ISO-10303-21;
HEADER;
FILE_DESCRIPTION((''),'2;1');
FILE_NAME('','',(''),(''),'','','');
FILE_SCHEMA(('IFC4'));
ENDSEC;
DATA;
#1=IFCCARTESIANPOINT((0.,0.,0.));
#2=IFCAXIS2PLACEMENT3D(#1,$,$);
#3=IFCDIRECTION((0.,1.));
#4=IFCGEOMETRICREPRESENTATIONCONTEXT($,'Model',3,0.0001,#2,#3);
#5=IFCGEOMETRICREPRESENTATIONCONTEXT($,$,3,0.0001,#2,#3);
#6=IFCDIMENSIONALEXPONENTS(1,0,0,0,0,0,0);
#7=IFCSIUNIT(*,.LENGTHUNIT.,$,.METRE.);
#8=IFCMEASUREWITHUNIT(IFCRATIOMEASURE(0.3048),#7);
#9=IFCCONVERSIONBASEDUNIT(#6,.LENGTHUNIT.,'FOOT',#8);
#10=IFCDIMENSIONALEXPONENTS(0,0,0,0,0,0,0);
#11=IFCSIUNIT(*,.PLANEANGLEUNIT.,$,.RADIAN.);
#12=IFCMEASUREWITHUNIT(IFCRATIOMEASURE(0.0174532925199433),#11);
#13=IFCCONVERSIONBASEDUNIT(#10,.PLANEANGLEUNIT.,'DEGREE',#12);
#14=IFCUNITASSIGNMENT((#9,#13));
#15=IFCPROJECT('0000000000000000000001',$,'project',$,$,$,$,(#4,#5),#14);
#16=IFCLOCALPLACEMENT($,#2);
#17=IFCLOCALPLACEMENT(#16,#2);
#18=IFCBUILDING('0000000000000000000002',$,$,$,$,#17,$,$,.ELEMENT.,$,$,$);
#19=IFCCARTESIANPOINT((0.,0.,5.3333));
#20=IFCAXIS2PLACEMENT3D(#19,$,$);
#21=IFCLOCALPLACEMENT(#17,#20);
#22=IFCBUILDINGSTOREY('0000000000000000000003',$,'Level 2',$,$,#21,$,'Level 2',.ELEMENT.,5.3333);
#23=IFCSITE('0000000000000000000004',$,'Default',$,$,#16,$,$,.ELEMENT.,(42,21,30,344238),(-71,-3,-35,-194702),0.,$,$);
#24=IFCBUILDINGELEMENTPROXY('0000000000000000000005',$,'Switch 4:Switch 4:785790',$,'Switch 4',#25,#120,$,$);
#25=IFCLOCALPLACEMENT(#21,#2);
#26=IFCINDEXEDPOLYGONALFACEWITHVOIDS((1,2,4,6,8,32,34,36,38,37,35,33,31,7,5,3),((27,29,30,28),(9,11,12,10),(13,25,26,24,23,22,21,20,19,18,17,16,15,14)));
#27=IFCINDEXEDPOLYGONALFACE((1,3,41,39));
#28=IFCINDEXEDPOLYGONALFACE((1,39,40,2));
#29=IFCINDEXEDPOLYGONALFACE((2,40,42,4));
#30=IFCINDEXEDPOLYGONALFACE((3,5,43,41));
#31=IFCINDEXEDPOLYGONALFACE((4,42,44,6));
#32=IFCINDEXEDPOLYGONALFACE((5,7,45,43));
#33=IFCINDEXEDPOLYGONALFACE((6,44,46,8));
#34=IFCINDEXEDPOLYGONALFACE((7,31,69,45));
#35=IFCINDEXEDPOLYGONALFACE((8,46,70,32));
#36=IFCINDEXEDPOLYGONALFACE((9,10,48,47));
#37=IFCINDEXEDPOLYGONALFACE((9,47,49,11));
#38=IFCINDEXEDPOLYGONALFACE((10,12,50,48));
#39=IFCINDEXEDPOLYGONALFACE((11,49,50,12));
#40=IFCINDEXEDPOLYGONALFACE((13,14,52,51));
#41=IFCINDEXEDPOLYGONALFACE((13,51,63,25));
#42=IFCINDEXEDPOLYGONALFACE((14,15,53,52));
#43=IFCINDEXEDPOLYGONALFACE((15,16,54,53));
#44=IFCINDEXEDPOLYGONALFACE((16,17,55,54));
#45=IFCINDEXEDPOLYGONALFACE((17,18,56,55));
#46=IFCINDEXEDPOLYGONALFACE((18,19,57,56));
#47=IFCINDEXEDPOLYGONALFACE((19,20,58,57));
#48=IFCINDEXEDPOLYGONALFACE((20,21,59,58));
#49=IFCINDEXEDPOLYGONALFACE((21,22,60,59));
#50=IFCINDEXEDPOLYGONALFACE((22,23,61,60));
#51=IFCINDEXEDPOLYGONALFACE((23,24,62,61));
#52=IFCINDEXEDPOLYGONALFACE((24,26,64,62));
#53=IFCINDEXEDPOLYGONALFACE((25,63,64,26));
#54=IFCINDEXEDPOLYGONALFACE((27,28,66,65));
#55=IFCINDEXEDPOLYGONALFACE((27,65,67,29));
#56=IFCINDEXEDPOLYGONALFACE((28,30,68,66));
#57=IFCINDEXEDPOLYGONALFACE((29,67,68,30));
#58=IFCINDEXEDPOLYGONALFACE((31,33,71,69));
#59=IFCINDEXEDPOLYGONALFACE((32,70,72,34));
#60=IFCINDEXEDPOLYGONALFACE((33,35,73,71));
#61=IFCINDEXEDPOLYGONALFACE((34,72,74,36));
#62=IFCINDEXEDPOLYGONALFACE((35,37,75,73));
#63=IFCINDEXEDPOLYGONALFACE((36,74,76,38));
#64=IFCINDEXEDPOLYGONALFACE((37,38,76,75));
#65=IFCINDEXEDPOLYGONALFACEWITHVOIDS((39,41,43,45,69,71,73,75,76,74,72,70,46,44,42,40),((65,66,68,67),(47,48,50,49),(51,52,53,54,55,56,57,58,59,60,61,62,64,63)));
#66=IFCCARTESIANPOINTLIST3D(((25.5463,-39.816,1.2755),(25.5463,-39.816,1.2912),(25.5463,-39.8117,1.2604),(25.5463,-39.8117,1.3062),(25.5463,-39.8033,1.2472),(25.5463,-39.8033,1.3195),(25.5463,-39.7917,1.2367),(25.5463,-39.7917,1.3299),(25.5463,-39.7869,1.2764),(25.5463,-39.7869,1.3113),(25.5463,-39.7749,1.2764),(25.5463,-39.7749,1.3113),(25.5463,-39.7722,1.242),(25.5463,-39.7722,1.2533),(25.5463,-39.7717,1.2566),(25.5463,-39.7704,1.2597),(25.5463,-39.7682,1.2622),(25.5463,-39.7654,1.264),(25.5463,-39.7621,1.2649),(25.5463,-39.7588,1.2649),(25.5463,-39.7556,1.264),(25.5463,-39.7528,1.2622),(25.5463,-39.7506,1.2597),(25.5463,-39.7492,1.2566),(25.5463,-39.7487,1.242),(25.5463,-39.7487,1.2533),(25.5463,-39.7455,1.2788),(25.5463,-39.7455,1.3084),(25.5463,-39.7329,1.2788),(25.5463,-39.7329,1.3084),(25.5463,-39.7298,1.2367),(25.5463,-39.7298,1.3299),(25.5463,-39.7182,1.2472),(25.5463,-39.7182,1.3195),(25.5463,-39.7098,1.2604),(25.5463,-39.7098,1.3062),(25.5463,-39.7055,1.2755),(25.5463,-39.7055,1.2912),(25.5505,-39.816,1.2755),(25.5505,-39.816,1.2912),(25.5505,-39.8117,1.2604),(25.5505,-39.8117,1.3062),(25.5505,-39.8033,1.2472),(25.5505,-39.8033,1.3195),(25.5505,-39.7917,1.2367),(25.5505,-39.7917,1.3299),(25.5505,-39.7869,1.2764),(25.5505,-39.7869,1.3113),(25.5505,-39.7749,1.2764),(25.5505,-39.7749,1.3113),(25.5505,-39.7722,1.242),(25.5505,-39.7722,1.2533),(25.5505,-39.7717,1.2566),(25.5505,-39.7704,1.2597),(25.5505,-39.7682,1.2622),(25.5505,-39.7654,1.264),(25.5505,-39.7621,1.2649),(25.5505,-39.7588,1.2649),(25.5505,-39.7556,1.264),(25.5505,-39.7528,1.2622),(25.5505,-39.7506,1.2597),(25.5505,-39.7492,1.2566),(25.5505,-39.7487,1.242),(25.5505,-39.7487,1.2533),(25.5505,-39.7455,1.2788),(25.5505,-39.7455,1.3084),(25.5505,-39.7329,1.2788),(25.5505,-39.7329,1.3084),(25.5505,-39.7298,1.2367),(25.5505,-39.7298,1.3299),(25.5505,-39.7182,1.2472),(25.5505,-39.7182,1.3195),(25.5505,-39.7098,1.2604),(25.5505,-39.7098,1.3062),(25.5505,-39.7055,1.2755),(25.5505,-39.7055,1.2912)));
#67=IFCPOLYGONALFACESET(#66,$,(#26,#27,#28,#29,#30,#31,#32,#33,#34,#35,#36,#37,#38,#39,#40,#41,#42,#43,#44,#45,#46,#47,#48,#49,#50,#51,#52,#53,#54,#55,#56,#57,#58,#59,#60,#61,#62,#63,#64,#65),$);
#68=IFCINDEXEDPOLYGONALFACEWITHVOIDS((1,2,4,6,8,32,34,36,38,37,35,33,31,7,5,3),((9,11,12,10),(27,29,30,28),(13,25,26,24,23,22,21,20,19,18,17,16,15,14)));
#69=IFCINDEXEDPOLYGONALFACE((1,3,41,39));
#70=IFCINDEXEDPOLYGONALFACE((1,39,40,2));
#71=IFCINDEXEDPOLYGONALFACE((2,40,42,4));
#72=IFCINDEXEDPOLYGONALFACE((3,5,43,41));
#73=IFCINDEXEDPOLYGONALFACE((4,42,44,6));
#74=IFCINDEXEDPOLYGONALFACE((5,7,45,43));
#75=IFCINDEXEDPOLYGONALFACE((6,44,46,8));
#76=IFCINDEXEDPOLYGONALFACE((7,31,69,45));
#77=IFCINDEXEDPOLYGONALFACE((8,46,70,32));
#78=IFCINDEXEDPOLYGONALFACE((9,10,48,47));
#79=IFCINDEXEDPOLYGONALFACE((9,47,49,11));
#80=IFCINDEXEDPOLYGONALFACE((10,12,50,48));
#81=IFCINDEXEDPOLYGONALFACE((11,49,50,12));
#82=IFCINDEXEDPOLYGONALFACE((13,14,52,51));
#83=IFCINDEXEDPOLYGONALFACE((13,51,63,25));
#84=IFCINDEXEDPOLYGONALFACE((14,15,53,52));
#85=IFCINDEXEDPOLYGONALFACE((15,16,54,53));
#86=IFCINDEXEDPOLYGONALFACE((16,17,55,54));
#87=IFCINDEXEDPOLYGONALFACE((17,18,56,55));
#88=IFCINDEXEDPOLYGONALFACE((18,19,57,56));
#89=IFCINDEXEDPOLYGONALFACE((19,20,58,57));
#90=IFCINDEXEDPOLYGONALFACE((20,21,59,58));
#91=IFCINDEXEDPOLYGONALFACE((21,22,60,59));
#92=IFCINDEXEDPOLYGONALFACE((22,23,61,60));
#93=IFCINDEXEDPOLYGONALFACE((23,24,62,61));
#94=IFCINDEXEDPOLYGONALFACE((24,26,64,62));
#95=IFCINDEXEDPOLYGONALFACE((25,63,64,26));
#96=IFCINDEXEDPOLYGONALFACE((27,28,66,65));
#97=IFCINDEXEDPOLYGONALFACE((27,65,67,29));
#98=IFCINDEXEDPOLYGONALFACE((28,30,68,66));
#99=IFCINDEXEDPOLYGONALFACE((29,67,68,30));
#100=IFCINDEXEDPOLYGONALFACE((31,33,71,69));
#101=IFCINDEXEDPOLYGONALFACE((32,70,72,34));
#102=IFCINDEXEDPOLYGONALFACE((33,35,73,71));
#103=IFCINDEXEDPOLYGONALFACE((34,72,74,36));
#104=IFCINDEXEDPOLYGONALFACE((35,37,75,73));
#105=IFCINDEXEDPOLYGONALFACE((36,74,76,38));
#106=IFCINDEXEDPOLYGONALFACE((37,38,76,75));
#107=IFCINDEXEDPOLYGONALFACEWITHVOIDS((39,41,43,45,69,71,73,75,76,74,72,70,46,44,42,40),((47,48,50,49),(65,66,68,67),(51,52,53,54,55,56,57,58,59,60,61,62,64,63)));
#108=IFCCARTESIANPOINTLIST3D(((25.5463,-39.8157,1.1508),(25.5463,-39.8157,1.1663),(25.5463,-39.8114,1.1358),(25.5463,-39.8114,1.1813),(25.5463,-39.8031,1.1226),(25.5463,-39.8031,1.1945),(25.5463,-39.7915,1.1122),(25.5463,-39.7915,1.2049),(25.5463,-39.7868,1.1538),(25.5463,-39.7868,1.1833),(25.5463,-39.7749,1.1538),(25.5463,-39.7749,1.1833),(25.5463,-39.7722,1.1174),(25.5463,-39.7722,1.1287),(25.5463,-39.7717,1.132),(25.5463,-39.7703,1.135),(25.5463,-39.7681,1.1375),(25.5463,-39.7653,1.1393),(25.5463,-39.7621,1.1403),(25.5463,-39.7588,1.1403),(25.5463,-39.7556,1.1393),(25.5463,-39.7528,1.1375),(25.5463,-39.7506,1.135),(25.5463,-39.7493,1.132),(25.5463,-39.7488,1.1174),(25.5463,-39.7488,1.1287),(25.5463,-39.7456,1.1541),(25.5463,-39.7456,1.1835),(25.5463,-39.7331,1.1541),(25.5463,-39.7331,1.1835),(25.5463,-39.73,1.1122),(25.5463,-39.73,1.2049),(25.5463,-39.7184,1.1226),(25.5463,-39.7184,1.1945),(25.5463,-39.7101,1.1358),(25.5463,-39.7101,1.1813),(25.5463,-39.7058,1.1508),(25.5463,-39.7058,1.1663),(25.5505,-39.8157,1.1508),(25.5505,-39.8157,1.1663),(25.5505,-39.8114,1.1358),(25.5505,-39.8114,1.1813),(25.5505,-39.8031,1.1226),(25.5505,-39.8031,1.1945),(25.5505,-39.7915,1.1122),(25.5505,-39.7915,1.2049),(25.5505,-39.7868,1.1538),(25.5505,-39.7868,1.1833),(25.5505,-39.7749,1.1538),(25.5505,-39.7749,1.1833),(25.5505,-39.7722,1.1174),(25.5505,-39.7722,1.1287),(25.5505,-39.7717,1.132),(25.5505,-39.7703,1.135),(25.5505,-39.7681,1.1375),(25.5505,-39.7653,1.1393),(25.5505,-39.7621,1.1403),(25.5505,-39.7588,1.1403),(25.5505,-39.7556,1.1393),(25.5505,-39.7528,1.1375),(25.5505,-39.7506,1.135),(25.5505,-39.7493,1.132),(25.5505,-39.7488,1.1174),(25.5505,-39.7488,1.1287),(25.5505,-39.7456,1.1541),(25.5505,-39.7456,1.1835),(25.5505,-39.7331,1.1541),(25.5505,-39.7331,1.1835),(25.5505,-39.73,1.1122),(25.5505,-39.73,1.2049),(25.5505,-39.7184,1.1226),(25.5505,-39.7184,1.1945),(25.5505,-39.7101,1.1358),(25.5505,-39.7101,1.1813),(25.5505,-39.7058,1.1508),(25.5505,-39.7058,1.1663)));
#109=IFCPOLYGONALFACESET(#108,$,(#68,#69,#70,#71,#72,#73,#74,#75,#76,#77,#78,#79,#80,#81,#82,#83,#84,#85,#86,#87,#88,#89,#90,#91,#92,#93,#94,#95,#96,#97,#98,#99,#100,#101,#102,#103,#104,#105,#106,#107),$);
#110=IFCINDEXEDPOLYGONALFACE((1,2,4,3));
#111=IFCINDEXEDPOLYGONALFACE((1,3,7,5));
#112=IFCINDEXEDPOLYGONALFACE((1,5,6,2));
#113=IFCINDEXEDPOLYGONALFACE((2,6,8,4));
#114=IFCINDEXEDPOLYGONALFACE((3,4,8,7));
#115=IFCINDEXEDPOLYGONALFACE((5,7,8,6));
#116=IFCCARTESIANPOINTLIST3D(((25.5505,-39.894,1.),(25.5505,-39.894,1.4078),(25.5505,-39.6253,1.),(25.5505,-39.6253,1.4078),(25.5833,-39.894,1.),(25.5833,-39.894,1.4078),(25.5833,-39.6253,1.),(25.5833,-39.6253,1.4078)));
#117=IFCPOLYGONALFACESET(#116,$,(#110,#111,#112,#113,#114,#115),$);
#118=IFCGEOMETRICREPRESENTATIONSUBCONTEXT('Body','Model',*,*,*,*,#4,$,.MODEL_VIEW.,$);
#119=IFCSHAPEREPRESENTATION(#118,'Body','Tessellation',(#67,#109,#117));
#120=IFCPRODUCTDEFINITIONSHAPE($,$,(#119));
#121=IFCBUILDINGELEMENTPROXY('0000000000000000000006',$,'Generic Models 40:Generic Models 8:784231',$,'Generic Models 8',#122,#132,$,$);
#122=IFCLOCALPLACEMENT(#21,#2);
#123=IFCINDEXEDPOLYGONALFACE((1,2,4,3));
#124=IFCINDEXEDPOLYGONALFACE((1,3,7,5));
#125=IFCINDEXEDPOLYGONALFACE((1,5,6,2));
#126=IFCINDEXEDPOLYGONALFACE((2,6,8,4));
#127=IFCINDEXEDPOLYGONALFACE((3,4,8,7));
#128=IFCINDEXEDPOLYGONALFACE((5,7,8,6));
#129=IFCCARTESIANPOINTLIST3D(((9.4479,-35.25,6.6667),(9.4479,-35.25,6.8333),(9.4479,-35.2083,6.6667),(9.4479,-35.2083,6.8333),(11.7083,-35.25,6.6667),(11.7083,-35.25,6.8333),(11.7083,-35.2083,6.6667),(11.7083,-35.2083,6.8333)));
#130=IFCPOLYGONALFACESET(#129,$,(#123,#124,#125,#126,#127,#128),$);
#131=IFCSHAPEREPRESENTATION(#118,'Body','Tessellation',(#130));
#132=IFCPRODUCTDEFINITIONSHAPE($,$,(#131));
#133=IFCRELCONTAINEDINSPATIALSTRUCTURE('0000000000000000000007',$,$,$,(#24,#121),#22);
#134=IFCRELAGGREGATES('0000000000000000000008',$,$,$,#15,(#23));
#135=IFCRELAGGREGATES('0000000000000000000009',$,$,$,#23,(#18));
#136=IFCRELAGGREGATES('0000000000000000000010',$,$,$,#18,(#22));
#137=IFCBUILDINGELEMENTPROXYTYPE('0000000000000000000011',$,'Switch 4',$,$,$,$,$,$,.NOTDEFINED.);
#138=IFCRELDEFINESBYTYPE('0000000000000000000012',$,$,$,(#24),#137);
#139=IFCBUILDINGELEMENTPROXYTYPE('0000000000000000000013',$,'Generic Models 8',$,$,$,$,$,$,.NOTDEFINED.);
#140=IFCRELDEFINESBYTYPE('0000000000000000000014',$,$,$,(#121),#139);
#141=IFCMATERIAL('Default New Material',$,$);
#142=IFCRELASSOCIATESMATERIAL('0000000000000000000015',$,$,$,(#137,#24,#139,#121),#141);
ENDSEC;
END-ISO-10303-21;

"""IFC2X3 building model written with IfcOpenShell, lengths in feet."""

from ifc_helpers import new_model, entity, si_unit, converted_unit, direction, frame, frame_2d, origin, origin_2d_with_axis, place, context, subcontext, project, spatial, polyline, circle_curve, parameter, trimmed, segment, composite_curve, rectangle, outline, extrude, source, transform, mapped, material, type_object, type_shapes, element, save


model = new_model("IFC2X3")

# Units and contexts
model_context = context("Model", 3, precision=0.0001, world=origin(), true_north=direction((0.0, 1.0)))
context_of_model = context(None, 3, precision=0.0001, world=origin(), true_north=direction((0.0, 1.0)))
body_context = subcontext(model_context, "Body", "Model", "MODEL_VIEW")
ifc_project = project(units=[converted_unit("LENGTHUNIT", "FOOT", entity("IfcRatioMeasure", 0.3048), si_unit("LENGTHUNIT", "METRE"), dimensions=[1, 0, 0, 0, 0, 0, 0]), converted_unit("PLANEANGLEUNIT", "DEGREE", entity("IfcRatioMeasure", 0.0174532925199433), si_unit("PLANEANGLEUNIT", "RADIAN"), dimensions=[0, 0, 0, 0, 0, 0, 0])], contexts=[model_context, context_of_model])

# Site, building, storey
site_placement = place(None, origin())
site = spatial("IfcSite", under=ifc_project, at=site_placement, Name="Default", CompositionType="ELEMENT", RefLatitude=(42, 21, 30, 344238), RefLongitude=(-71, -3, -35, -194702), RefElevation=0.0)
building_placement = place(site_placement, origin())
building = spatial("IfcBuilding", under=site, at=building_placement, CompositionType="ELEMENT")
storey_placement = place(building_placement, frame((0.0, 0.0, 5.3333)))
storey = spatial("IfcBuildingStorey", under=building, at=storey_placement, Name="Level 2", LongName="Level 2", CompositionType="ELEMENT", Elevation=5.3333)

# Shared definitions
ifc_material_1 = material(Name="Default New Material")

# Building element proxies
building_element_proxy_type_1 = type_object("IfcBuildingElementProxyType", Name="Switch 4", PredefinedType="NOTDEFINED", material=ifc_material_1)
shared_shape_1 = source(origin(), body_context, "Body", "SweptSolid", [
    extrude(outline(composite_curve([segment(polyline([(-0.0309, -0.0466), (0.0309, -0.0466)]), True, "CONTINUOUS"), segment(trimmed(circle_curve(frame_2d((-0.0003, 0.0), x_axis=(-1.0, 0.0)), 0.0561), [parameter(123.794741)], [parameter(236.205259)], True, "PARAMETER"), True, "CONTINUOUS"), segment(polyline([(0.0309, 0.0466), (-0.0309, 0.0466)]), True, "CONTINUOUS"), segment(trimmed(circle_curve(frame_2d((0.0003, 0.0), x_axis=(1.0, 0.0)), 0.0561), [parameter(123.794741)], [parameter(236.205259)], True, "PARAMETER"), True, "CONTINUOUS")], self_intersect=False), holes=[polyline([(0.0142, 0.0279), (0.0262, 0.0279), (0.0262, -0.0069), (0.0142, -0.0069), (0.0142, 0.0279)]), polyline([(-0.0153, 0.025), (-0.0153, -0.0045), (-0.0278, -0.0045), (-0.0278, 0.025), (-0.0153, 0.025)]), composite_curve([segment(polyline([(-0.012, -0.0413), (-0.012, -0.03)]), True, "CONTINUOUS"), segment(trimmed(circle_curve(frame_2d((-0.0003, -0.03), x_axis=(-1.0, 0.0)), 0.0117), [parameter(180.0)], [parameter(0.0)], True, "PARAMETER"), False, "CONTINUOUS"), segment(polyline([(0.0115, -0.03), (0.0115, -0.0413)]), True, "CONTINUOUS"), segment(polyline([(0.0115, -0.0413), (-0.012, -0.0413)]), True, "CONTINUOUS")], self_intersect=False)]), frame((-0.0011, 0.0328, 0.2833), z_axis=(0.0, 1.0, 0.0), x_axis=(-1.0, 0.0, 0.0)), (0.0, 0.0, 1.0), 0.0042),
    extrude(outline(composite_curve([segment(polyline([(-0.0308, -0.0464), (0.0308, -0.0464)]), True, "CONTINUOUS"), segment(trimmed(circle_curve(frame_2d((-0.0003, 0.0), x_axis=(-1.0, 0.0)), 0.0558), [parameter(123.794741)], [parameter(236.205259)], True, "PARAMETER"), True, "CONTINUOUS"), segment(polyline([(0.0308, 0.0464), (-0.0308, 0.0464)]), True, "CONTINUOUS"), segment(trimmed(circle_curve(frame_2d((0.0003, 0.0), x_axis=(1.0, 0.0)), 0.0558), [parameter(123.794741)], [parameter(236.205259)], True, "PARAMETER"), True, "CONTINUOUS")], self_intersect=False), holes=[polyline([(0.0141, 0.0247), (0.026, 0.0247), (0.026, -0.0047), (0.0141, -0.0047), (0.0141, 0.0247)]), polyline([(-0.0152, 0.0249), (-0.0152, -0.0045), (-0.0277, -0.0045), (-0.0277, 0.0249), (-0.0152, 0.0249)]), composite_curve([segment(polyline([(-0.012, -0.0411), (-0.012, -0.0299)]), True, "CONTINUOUS"), segment(trimmed(circle_curve(frame_2d((-0.0003, -0.0299), x_axis=(-1.0, 0.0)), 0.0117), [parameter(180.0)], [parameter(0.0)], True, "PARAMETER"), False, "CONTINUOUS"), segment(polyline([(0.0114, -0.0299), (0.0114, -0.0411)]), True, "CONTINUOUS"), segment(polyline([(0.0114, -0.0411), (-0.012, -0.0411)]), True, "CONTINUOUS")], self_intersect=False)]), frame((-0.0011, 0.0328, 0.1586), z_axis=(0.0, 1.0, 0.0), x_axis=(-1.0, 0.0, 0.0)), (0.0, 0.0, 1.0), 0.0042),
    extrude(rectangle(XDim=0.0328, YDim=0.2687, at=origin_2d_with_axis()), frame((0.0, 0.0164, 0.0), z_axis=(0.0, 0.0, 1.0), x_axis=(0.0, -1.0, 0.0)), (0.0, 0.0, 1.0), 0.4078),
])
type_shapes(building_element_proxy_type_1, [shared_shape_1])
proxy_1_placement = place(storey_placement, frame((25.5833, -39.7596, 1.0), z_axis=(0.0, 0.0, 1.0), x_axis=(0.0, 1.0, 0.0)))
element("IfcBuildingElementProxy", 1, at=proxy_1_placement, inside=storey, type_object=building_element_proxy_type_1, material=ifc_material_1, Name="Switch 4:Switch 4:785790", ObjectType="Switch 4", context=body_context, shape_type="MappedRepresentation", body=[
    mapped(shared_shape_1, transform((0.0, 0.0, 0.0), scale=1.0)),
])
building_element_proxy_type_2 = type_object("IfcBuildingElementProxyType", Name="Generic Models 8", PredefinedType="NOTDEFINED", material=ifc_material_1)
shared_shape_2 = source(origin(), body_context, "Body", "SweptSolid", [
    extrude(rectangle(XDim=0.0417, YDim=2.2604, at=frame_2d((0.0, 0.0), x_axis=(1.0, 0.0))), frame((1.1302, 0.0208, 0.0), z_axis=(0.0, 0.0, 1.0), x_axis=(0.0, 1.0, 0.0)), (0.0, 0.0, 1.0), 0.1667),
])
type_shapes(building_element_proxy_type_2, [shared_shape_2])
proxy_2_placement = place(storey_placement, frame((9.4479, -35.25, 6.6667)))
element("IfcBuildingElementProxy", 2, at=proxy_2_placement, inside=storey, type_object=building_element_proxy_type_2, material=ifc_material_1, Name="Generic Models 40:Generic Models 8:784231", ObjectType="Generic Models 8", context=body_context, shape_type="MappedRepresentation", body=[
    mapped(shared_shape_2, transform((0.0, 0.0, 0.0), scale=1.0)),
])

save(model, "model.ifc")
